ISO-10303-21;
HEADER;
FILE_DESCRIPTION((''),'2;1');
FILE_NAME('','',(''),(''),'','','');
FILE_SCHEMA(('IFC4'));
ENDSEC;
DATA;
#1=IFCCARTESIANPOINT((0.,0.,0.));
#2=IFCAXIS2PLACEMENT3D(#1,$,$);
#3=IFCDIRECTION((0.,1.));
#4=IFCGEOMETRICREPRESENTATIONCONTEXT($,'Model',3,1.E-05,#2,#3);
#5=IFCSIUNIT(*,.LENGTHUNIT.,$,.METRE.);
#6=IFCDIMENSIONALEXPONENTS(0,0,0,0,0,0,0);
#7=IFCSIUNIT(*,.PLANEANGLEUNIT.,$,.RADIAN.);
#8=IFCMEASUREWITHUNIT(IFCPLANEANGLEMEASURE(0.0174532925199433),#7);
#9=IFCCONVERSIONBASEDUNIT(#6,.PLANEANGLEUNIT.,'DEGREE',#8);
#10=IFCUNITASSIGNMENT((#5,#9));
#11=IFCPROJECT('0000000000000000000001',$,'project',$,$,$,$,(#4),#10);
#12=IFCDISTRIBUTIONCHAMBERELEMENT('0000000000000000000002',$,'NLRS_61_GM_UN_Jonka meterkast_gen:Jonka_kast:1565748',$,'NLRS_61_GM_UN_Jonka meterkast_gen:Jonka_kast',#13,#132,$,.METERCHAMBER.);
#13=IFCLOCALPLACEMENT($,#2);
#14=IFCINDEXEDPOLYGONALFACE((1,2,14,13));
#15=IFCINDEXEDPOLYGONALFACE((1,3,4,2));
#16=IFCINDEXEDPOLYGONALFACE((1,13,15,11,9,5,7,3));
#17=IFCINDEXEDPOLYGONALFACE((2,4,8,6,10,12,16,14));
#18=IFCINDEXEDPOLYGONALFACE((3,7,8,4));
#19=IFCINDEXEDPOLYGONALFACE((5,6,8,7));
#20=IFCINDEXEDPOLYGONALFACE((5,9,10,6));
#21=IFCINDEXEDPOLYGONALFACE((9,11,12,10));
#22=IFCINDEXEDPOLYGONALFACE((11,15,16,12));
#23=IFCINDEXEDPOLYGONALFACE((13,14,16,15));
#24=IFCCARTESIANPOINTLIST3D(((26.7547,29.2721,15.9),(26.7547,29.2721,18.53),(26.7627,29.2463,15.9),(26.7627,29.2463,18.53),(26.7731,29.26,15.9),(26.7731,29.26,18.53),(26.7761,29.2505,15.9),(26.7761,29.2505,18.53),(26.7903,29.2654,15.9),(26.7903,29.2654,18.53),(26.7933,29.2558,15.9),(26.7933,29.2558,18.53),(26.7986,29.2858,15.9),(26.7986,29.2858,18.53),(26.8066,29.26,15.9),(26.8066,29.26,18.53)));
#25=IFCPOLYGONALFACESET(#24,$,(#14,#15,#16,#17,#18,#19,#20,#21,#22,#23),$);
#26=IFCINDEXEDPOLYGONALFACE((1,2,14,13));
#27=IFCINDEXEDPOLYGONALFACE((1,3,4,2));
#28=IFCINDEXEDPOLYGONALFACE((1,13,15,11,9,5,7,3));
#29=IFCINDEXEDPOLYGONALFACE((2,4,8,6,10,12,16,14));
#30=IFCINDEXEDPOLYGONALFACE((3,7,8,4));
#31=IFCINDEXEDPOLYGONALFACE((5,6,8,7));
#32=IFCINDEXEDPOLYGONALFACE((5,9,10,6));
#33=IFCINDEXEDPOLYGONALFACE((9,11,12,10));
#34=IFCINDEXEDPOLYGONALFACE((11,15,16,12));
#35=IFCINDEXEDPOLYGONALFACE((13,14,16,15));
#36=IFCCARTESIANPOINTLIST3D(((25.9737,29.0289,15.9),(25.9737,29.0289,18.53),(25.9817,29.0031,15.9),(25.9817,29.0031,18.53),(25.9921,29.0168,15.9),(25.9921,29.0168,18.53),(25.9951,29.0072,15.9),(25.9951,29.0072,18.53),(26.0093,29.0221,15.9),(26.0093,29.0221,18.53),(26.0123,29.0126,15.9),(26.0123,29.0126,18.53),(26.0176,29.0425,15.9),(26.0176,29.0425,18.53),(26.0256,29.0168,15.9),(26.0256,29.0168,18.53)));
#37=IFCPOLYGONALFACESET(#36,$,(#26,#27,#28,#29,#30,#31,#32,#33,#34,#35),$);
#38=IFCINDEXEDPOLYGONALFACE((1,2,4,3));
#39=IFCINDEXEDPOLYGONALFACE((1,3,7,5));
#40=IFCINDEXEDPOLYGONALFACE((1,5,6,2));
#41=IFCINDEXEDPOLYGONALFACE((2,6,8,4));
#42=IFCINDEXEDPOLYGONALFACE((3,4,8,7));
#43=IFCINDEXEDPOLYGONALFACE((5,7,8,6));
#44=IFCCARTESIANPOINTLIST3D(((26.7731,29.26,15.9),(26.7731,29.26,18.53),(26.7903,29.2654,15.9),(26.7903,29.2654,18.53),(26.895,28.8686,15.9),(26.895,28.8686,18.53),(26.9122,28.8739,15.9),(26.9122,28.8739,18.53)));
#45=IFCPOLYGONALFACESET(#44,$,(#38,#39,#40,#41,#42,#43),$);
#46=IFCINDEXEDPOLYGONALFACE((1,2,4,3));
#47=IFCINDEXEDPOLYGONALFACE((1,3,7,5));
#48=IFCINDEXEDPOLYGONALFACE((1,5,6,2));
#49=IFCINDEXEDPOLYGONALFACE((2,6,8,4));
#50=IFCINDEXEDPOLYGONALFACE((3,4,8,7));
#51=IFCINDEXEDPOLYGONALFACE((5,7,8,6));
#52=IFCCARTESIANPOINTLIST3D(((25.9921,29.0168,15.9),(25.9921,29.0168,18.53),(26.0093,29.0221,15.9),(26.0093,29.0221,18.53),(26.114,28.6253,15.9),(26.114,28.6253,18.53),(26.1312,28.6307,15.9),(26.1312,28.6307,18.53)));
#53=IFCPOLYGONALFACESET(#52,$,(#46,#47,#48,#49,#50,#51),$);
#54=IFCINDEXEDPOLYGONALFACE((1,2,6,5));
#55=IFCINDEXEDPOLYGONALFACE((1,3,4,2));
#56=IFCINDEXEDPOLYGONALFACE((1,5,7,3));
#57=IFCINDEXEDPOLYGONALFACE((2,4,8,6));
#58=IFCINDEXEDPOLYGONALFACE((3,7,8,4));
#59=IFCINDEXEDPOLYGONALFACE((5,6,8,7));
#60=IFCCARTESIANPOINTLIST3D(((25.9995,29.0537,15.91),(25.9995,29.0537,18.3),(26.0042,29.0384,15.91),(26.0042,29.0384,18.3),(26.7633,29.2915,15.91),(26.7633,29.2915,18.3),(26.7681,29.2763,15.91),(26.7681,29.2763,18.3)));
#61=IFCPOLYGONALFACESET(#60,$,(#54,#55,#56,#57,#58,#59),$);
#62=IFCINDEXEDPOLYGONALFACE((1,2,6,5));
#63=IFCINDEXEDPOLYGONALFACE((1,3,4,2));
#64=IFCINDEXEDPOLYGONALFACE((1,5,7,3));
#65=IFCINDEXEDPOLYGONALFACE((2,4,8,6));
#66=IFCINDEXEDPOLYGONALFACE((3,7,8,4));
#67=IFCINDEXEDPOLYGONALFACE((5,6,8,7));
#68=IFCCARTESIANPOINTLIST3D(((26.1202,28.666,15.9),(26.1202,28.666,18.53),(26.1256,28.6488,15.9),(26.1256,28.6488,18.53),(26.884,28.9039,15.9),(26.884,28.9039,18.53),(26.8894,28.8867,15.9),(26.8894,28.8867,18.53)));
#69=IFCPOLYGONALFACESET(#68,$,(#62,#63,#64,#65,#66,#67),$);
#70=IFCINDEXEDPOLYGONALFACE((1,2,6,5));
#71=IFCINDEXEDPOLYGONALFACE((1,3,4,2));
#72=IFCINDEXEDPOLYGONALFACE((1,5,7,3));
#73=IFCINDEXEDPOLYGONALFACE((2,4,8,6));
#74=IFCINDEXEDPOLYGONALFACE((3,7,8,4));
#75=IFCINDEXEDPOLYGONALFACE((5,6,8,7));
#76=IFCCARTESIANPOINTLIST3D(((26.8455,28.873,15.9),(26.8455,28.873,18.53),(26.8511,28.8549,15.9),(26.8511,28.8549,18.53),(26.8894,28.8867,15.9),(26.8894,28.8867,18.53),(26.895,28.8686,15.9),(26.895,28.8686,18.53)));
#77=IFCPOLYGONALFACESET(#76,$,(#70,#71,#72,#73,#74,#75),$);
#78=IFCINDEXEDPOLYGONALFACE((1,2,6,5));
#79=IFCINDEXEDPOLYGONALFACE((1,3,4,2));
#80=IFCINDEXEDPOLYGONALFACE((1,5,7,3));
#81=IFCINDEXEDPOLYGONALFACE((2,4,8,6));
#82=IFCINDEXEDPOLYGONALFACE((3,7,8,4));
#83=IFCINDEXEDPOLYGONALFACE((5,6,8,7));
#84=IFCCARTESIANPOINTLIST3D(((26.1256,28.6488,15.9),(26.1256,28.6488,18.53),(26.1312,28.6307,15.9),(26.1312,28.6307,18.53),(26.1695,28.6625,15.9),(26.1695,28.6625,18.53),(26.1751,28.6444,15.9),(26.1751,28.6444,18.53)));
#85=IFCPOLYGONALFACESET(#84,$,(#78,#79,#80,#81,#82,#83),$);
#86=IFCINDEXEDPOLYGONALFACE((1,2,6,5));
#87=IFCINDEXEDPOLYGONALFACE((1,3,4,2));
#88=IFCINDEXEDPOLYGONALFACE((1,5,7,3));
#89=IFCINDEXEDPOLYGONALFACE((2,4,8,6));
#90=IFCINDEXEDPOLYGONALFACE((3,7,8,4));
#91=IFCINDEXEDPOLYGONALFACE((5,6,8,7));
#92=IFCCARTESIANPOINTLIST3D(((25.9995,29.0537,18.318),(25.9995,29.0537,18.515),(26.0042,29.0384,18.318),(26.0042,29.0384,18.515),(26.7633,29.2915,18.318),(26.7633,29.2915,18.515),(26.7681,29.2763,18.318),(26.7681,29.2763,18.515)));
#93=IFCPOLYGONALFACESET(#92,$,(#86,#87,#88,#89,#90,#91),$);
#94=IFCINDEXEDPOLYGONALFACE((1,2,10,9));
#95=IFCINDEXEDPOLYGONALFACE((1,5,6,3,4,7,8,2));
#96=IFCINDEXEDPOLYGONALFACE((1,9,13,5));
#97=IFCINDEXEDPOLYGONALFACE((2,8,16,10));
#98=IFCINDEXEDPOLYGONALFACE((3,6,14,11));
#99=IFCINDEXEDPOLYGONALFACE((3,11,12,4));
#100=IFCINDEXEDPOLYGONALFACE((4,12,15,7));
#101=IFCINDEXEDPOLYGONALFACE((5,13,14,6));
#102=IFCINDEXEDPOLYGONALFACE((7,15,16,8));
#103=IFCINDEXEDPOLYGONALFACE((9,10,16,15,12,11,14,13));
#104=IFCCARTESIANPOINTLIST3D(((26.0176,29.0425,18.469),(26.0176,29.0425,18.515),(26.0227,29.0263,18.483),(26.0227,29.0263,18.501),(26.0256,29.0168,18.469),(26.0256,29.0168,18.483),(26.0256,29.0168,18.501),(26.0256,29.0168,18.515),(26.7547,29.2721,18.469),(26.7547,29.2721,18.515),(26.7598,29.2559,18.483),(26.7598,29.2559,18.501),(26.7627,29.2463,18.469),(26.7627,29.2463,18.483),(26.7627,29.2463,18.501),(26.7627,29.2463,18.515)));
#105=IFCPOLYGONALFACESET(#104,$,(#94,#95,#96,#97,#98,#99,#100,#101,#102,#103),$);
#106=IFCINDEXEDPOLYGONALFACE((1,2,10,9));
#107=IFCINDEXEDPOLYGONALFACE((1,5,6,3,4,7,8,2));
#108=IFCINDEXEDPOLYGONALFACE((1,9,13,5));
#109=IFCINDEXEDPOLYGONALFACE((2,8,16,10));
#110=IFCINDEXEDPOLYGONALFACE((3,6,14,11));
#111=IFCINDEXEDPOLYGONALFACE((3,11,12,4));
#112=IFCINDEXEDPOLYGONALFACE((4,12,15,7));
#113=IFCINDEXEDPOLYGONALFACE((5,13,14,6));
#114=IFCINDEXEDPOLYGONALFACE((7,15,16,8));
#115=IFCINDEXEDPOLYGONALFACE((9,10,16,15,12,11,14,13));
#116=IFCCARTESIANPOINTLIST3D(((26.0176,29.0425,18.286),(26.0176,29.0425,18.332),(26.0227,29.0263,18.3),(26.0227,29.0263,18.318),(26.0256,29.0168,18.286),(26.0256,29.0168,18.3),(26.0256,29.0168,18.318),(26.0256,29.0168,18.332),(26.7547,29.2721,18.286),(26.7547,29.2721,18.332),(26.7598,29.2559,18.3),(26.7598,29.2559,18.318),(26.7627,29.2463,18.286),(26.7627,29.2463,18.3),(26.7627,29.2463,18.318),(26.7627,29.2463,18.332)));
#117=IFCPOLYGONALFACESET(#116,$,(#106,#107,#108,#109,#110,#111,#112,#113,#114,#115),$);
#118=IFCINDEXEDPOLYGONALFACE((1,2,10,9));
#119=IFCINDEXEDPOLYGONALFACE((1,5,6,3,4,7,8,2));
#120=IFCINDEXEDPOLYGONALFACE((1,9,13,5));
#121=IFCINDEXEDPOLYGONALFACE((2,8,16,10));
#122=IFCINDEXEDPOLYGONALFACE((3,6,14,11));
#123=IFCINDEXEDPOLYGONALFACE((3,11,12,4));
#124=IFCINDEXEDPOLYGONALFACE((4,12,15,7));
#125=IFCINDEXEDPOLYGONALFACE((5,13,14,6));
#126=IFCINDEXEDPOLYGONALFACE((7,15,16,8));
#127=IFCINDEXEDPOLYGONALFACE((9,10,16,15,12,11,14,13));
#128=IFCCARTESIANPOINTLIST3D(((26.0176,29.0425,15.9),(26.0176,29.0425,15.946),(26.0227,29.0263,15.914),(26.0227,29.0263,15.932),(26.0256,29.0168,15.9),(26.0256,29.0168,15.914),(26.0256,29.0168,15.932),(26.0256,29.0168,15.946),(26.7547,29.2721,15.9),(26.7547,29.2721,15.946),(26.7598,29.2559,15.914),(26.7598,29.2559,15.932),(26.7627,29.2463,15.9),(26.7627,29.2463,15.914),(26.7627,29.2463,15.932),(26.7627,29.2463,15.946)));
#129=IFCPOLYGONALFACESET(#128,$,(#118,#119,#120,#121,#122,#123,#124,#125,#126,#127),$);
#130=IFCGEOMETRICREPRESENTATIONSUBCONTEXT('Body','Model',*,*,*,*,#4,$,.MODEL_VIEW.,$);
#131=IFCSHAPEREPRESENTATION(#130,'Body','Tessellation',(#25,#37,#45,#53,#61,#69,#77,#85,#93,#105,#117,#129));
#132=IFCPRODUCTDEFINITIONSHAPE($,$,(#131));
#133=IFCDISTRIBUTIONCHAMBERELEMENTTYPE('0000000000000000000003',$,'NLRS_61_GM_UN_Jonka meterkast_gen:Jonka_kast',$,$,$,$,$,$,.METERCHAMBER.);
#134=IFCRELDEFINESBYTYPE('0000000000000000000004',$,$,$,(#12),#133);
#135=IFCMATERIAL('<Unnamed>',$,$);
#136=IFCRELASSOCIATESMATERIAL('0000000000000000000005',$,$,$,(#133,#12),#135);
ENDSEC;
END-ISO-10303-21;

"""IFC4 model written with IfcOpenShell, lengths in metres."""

from ifc_helpers import new_model, entity, si_unit, converted_unit, direction, frame, origin, place, context, subcontext, project, indexed_curve, outline, extrude, source, transform, mapped, material, type_object, type_shapes, element, save


model = new_model("IFC4")

# Units and contexts
model_context = context("Model", 3, precision=1e-05, world=origin(), true_north=direction((0.0, 1.0)))
body_context = subcontext(model_context, "Body", "Model", "MODEL_VIEW")
ifc_project = project(units=[si_unit("LENGTHUNIT", "METRE"), converted_unit("PLANEANGLEUNIT", "DEGREE", entity("IfcPlaneAngleMeasure", 0.0174532925199433), si_unit("PLANEANGLEUNIT", "RADIAN"), dimensions=[0, 0, 0, 0, 0, 0, 0])], contexts=[model_context])

# Distribution chamber element
ifc_material = material(Name="<Unnamed>")
distribution_chamber_element_type = type_object("IfcDistributionChamberElementType", Name="NLRS_61_GM_UN_Jonka meterkast_gen:Jonka_kast", PredefinedType="METERCHAMBER", material=ifc_material)
shared_shape_1 = source(origin(), body_context, "Body", "SweptSolid", [
    extrude(outline(indexed_curve([(-0.0093, -0.023), (0.0178, -0.023), (0.0178, 0.023), (-0.0093, 0.023), (-0.0093, 0.009), (0.0007, 0.009), (0.0007, -0.009), (-0.0093, -0.009), (-0.0093, -0.023)], self_intersect=False)), frame((-0.409, -0.4092, 0.0), z_axis=(0.0, 0.0, 1.0), x_axis=(0.0, -1.0, 0.0)), (0.0, 0.0, 1.0), 2.63),
    extrude(outline(indexed_curve([(-0.0093, -0.023), (0.0178, -0.023), (0.0178, 0.023), (-0.0093, 0.023), (-0.0093, 0.009), (0.0007, 0.009), (0.0007, -0.009), (-0.0093, -0.009), (-0.0093, -0.023)], self_intersect=False)), frame((0.409, -0.4092, 0.0), z_axis=(0.0, 0.0, 1.0), x_axis=(0.0, -1.0, 0.0)), (0.0, 0.0, 1.0), 2.63),
    extrude(outline(indexed_curve([(-0.205, -0.009), (0.205, -0.009), (0.205, 0.009), (-0.205, 0.009), (-0.205, -0.009)], self_intersect=False)), frame((-0.409, -0.205, 0.0), z_axis=(0.0, 0.0, 1.0), x_axis=(0.0, -1.0, 0.0)), (0.0, 0.0, 1.0), 2.63),
    extrude(outline(indexed_curve([(-0.205, -0.009), (0.205, -0.009), (0.205, 0.009), (-0.205, 0.009), (-0.205, -0.009)], self_intersect=False)), frame((0.409, -0.205, 0.0), z_axis=(0.0, 0.0, 1.0), x_axis=(0.0, -1.0, 0.0)), (0.0, 0.0, 1.0), 2.63),
    extrude(outline(indexed_curve([(-0.4, -0.008), (0.4, -0.008), (0.4, 0.008), (-0.4, 0.008), (-0.4, -0.008)], self_intersect=False)), frame((0.0, -0.435, 0.01), z_axis=(0.0, 0.0, 1.0), x_axis=(-1.0, 0.0, 0.0)), (0.0, 0.0, 1.0), 2.39),
    extrude(outline(indexed_curve([(-0.4, -0.009), (0.4, -0.009), (0.4, 0.009), (-0.4, 0.009), (-0.4, -0.009)], self_intersect=False)), frame((0.0, -0.028, 0.0), z_axis=(0.0, 0.0, 1.0), x_axis=(-1.0, 0.0, 0.0)), (0.0, 0.0, 1.0), 2.63),
    extrude(outline(indexed_curve([(-0.023, -0.0095), (0.023, -0.0095), (0.023, 0.0095), (-0.023, 0.0095), (-0.023, -0.0095)], self_intersect=False)), frame((-0.377, -0.0095, 0.0), z_axis=(0.0, 0.0, 1.0), x_axis=(-1.0, 0.0, 0.0)), (0.0, 0.0, 1.0), 2.63),
    extrude(outline(indexed_curve([(-0.023, -0.0095), (0.023, -0.0095), (0.023, 0.0095), (-0.023, 0.0095), (-0.023, -0.0095)], self_intersect=False)), frame((0.377, -0.0095, 0.0), z_axis=(0.0, 0.0, 1.0), x_axis=(-1.0, 0.0, 0.0)), (0.0, 0.0, 1.0), 2.63),
    extrude(outline(indexed_curve([(-0.4, -0.008), (0.4, -0.008), (0.4, 0.008), (-0.4, 0.008), (-0.4, -0.008)], self_intersect=False)), frame((0.0, -0.435, 2.418), z_axis=(0.0, 0.0, 1.0), x_axis=(-1.0, 0.0, 0.0)), (0.0, 0.0, 1.0), 0.197),
    extrude(outline(indexed_curve([(-0.023, -0.0178), (0.023, -0.0178), (0.023, 0.0093), (0.009, 0.0093), (0.009, -0.0007), (-0.009, -0.0007), (-0.009, 0.0093), (-0.023, 0.0093), (-0.023, -0.0178)], self_intersect=False)), frame((-0.386, -0.4092, 2.592), z_axis=(1.0, 0.0, 0.0), x_axis=(0.0, 0.0, -1.0)), (0.0, 0.0, 1.0), 0.772),
    extrude(outline(indexed_curve([(-0.023, -0.0178), (0.023, -0.0178), (0.023, 0.0093), (0.009, 0.0093), (0.009, -0.0007), (-0.009, -0.0007), (-0.009, 0.0093), (-0.023, 0.0093), (-0.023, -0.0178)], self_intersect=False)), frame((-0.386, -0.4092, 2.409), z_axis=(1.0, 0.0, 0.0), x_axis=(0.0, 0.0, -1.0)), (0.0, 0.0, 1.0), 0.772),
    extrude(outline(indexed_curve([(-0.023, -0.0178), (0.023, -0.0178), (0.023, 0.0093), (0.009, 0.0093), (0.009, -0.0007), (-0.009, -0.0007), (-0.009, 0.0093), (-0.023, 0.0093), (-0.023, -0.0178)], self_intersect=False)), frame((-0.386, -0.4092, 0.023), z_axis=(1.0, 0.0, 0.0), x_axis=(0.0, 0.0, -1.0)), (0.0, 0.0, 1.0), 0.772),
])
type_shapes(distribution_chamber_element_type, [shared_shape_1])
placement_1 = place(None, frame((13.1348, 11.9886, 0.0), z_axis=(0.0, 0.0, 1.0), x_axis=(0.954771, 0.297342, 0.0)))
placement_2 = place(placement_1, origin())
placement_3 = place(placement_2, frame((0.0, 0.0, 15.9)))
placement_4 = place(placement_3, origin())
distribution_chamber_element_1_placement = place(placement_4, frame((17.757, 12.025, 0.0), z_axis=(0.0, 0.0, 1.0), x_axis=(-1.0, 0.0, 0.0)))
element("IfcDistributionChamberElement", 1, at=distribution_chamber_element_1_placement, type_object=distribution_chamber_element_type, material=ifc_material, Name="NLRS_61_GM_UN_Jonka meterkast_gen:Jonka_kast:1565748", ObjectType="NLRS_61_GM_UN_Jonka meterkast_gen:Jonka_kast", PredefinedType="METERCHAMBER", context=body_context, shape_type="MappedRepresentation", body=[
    mapped(shared_shape_1, transform((0.0, 0.0, 0.0), scale=1.0)),
])

save(model, "model.ifc")
